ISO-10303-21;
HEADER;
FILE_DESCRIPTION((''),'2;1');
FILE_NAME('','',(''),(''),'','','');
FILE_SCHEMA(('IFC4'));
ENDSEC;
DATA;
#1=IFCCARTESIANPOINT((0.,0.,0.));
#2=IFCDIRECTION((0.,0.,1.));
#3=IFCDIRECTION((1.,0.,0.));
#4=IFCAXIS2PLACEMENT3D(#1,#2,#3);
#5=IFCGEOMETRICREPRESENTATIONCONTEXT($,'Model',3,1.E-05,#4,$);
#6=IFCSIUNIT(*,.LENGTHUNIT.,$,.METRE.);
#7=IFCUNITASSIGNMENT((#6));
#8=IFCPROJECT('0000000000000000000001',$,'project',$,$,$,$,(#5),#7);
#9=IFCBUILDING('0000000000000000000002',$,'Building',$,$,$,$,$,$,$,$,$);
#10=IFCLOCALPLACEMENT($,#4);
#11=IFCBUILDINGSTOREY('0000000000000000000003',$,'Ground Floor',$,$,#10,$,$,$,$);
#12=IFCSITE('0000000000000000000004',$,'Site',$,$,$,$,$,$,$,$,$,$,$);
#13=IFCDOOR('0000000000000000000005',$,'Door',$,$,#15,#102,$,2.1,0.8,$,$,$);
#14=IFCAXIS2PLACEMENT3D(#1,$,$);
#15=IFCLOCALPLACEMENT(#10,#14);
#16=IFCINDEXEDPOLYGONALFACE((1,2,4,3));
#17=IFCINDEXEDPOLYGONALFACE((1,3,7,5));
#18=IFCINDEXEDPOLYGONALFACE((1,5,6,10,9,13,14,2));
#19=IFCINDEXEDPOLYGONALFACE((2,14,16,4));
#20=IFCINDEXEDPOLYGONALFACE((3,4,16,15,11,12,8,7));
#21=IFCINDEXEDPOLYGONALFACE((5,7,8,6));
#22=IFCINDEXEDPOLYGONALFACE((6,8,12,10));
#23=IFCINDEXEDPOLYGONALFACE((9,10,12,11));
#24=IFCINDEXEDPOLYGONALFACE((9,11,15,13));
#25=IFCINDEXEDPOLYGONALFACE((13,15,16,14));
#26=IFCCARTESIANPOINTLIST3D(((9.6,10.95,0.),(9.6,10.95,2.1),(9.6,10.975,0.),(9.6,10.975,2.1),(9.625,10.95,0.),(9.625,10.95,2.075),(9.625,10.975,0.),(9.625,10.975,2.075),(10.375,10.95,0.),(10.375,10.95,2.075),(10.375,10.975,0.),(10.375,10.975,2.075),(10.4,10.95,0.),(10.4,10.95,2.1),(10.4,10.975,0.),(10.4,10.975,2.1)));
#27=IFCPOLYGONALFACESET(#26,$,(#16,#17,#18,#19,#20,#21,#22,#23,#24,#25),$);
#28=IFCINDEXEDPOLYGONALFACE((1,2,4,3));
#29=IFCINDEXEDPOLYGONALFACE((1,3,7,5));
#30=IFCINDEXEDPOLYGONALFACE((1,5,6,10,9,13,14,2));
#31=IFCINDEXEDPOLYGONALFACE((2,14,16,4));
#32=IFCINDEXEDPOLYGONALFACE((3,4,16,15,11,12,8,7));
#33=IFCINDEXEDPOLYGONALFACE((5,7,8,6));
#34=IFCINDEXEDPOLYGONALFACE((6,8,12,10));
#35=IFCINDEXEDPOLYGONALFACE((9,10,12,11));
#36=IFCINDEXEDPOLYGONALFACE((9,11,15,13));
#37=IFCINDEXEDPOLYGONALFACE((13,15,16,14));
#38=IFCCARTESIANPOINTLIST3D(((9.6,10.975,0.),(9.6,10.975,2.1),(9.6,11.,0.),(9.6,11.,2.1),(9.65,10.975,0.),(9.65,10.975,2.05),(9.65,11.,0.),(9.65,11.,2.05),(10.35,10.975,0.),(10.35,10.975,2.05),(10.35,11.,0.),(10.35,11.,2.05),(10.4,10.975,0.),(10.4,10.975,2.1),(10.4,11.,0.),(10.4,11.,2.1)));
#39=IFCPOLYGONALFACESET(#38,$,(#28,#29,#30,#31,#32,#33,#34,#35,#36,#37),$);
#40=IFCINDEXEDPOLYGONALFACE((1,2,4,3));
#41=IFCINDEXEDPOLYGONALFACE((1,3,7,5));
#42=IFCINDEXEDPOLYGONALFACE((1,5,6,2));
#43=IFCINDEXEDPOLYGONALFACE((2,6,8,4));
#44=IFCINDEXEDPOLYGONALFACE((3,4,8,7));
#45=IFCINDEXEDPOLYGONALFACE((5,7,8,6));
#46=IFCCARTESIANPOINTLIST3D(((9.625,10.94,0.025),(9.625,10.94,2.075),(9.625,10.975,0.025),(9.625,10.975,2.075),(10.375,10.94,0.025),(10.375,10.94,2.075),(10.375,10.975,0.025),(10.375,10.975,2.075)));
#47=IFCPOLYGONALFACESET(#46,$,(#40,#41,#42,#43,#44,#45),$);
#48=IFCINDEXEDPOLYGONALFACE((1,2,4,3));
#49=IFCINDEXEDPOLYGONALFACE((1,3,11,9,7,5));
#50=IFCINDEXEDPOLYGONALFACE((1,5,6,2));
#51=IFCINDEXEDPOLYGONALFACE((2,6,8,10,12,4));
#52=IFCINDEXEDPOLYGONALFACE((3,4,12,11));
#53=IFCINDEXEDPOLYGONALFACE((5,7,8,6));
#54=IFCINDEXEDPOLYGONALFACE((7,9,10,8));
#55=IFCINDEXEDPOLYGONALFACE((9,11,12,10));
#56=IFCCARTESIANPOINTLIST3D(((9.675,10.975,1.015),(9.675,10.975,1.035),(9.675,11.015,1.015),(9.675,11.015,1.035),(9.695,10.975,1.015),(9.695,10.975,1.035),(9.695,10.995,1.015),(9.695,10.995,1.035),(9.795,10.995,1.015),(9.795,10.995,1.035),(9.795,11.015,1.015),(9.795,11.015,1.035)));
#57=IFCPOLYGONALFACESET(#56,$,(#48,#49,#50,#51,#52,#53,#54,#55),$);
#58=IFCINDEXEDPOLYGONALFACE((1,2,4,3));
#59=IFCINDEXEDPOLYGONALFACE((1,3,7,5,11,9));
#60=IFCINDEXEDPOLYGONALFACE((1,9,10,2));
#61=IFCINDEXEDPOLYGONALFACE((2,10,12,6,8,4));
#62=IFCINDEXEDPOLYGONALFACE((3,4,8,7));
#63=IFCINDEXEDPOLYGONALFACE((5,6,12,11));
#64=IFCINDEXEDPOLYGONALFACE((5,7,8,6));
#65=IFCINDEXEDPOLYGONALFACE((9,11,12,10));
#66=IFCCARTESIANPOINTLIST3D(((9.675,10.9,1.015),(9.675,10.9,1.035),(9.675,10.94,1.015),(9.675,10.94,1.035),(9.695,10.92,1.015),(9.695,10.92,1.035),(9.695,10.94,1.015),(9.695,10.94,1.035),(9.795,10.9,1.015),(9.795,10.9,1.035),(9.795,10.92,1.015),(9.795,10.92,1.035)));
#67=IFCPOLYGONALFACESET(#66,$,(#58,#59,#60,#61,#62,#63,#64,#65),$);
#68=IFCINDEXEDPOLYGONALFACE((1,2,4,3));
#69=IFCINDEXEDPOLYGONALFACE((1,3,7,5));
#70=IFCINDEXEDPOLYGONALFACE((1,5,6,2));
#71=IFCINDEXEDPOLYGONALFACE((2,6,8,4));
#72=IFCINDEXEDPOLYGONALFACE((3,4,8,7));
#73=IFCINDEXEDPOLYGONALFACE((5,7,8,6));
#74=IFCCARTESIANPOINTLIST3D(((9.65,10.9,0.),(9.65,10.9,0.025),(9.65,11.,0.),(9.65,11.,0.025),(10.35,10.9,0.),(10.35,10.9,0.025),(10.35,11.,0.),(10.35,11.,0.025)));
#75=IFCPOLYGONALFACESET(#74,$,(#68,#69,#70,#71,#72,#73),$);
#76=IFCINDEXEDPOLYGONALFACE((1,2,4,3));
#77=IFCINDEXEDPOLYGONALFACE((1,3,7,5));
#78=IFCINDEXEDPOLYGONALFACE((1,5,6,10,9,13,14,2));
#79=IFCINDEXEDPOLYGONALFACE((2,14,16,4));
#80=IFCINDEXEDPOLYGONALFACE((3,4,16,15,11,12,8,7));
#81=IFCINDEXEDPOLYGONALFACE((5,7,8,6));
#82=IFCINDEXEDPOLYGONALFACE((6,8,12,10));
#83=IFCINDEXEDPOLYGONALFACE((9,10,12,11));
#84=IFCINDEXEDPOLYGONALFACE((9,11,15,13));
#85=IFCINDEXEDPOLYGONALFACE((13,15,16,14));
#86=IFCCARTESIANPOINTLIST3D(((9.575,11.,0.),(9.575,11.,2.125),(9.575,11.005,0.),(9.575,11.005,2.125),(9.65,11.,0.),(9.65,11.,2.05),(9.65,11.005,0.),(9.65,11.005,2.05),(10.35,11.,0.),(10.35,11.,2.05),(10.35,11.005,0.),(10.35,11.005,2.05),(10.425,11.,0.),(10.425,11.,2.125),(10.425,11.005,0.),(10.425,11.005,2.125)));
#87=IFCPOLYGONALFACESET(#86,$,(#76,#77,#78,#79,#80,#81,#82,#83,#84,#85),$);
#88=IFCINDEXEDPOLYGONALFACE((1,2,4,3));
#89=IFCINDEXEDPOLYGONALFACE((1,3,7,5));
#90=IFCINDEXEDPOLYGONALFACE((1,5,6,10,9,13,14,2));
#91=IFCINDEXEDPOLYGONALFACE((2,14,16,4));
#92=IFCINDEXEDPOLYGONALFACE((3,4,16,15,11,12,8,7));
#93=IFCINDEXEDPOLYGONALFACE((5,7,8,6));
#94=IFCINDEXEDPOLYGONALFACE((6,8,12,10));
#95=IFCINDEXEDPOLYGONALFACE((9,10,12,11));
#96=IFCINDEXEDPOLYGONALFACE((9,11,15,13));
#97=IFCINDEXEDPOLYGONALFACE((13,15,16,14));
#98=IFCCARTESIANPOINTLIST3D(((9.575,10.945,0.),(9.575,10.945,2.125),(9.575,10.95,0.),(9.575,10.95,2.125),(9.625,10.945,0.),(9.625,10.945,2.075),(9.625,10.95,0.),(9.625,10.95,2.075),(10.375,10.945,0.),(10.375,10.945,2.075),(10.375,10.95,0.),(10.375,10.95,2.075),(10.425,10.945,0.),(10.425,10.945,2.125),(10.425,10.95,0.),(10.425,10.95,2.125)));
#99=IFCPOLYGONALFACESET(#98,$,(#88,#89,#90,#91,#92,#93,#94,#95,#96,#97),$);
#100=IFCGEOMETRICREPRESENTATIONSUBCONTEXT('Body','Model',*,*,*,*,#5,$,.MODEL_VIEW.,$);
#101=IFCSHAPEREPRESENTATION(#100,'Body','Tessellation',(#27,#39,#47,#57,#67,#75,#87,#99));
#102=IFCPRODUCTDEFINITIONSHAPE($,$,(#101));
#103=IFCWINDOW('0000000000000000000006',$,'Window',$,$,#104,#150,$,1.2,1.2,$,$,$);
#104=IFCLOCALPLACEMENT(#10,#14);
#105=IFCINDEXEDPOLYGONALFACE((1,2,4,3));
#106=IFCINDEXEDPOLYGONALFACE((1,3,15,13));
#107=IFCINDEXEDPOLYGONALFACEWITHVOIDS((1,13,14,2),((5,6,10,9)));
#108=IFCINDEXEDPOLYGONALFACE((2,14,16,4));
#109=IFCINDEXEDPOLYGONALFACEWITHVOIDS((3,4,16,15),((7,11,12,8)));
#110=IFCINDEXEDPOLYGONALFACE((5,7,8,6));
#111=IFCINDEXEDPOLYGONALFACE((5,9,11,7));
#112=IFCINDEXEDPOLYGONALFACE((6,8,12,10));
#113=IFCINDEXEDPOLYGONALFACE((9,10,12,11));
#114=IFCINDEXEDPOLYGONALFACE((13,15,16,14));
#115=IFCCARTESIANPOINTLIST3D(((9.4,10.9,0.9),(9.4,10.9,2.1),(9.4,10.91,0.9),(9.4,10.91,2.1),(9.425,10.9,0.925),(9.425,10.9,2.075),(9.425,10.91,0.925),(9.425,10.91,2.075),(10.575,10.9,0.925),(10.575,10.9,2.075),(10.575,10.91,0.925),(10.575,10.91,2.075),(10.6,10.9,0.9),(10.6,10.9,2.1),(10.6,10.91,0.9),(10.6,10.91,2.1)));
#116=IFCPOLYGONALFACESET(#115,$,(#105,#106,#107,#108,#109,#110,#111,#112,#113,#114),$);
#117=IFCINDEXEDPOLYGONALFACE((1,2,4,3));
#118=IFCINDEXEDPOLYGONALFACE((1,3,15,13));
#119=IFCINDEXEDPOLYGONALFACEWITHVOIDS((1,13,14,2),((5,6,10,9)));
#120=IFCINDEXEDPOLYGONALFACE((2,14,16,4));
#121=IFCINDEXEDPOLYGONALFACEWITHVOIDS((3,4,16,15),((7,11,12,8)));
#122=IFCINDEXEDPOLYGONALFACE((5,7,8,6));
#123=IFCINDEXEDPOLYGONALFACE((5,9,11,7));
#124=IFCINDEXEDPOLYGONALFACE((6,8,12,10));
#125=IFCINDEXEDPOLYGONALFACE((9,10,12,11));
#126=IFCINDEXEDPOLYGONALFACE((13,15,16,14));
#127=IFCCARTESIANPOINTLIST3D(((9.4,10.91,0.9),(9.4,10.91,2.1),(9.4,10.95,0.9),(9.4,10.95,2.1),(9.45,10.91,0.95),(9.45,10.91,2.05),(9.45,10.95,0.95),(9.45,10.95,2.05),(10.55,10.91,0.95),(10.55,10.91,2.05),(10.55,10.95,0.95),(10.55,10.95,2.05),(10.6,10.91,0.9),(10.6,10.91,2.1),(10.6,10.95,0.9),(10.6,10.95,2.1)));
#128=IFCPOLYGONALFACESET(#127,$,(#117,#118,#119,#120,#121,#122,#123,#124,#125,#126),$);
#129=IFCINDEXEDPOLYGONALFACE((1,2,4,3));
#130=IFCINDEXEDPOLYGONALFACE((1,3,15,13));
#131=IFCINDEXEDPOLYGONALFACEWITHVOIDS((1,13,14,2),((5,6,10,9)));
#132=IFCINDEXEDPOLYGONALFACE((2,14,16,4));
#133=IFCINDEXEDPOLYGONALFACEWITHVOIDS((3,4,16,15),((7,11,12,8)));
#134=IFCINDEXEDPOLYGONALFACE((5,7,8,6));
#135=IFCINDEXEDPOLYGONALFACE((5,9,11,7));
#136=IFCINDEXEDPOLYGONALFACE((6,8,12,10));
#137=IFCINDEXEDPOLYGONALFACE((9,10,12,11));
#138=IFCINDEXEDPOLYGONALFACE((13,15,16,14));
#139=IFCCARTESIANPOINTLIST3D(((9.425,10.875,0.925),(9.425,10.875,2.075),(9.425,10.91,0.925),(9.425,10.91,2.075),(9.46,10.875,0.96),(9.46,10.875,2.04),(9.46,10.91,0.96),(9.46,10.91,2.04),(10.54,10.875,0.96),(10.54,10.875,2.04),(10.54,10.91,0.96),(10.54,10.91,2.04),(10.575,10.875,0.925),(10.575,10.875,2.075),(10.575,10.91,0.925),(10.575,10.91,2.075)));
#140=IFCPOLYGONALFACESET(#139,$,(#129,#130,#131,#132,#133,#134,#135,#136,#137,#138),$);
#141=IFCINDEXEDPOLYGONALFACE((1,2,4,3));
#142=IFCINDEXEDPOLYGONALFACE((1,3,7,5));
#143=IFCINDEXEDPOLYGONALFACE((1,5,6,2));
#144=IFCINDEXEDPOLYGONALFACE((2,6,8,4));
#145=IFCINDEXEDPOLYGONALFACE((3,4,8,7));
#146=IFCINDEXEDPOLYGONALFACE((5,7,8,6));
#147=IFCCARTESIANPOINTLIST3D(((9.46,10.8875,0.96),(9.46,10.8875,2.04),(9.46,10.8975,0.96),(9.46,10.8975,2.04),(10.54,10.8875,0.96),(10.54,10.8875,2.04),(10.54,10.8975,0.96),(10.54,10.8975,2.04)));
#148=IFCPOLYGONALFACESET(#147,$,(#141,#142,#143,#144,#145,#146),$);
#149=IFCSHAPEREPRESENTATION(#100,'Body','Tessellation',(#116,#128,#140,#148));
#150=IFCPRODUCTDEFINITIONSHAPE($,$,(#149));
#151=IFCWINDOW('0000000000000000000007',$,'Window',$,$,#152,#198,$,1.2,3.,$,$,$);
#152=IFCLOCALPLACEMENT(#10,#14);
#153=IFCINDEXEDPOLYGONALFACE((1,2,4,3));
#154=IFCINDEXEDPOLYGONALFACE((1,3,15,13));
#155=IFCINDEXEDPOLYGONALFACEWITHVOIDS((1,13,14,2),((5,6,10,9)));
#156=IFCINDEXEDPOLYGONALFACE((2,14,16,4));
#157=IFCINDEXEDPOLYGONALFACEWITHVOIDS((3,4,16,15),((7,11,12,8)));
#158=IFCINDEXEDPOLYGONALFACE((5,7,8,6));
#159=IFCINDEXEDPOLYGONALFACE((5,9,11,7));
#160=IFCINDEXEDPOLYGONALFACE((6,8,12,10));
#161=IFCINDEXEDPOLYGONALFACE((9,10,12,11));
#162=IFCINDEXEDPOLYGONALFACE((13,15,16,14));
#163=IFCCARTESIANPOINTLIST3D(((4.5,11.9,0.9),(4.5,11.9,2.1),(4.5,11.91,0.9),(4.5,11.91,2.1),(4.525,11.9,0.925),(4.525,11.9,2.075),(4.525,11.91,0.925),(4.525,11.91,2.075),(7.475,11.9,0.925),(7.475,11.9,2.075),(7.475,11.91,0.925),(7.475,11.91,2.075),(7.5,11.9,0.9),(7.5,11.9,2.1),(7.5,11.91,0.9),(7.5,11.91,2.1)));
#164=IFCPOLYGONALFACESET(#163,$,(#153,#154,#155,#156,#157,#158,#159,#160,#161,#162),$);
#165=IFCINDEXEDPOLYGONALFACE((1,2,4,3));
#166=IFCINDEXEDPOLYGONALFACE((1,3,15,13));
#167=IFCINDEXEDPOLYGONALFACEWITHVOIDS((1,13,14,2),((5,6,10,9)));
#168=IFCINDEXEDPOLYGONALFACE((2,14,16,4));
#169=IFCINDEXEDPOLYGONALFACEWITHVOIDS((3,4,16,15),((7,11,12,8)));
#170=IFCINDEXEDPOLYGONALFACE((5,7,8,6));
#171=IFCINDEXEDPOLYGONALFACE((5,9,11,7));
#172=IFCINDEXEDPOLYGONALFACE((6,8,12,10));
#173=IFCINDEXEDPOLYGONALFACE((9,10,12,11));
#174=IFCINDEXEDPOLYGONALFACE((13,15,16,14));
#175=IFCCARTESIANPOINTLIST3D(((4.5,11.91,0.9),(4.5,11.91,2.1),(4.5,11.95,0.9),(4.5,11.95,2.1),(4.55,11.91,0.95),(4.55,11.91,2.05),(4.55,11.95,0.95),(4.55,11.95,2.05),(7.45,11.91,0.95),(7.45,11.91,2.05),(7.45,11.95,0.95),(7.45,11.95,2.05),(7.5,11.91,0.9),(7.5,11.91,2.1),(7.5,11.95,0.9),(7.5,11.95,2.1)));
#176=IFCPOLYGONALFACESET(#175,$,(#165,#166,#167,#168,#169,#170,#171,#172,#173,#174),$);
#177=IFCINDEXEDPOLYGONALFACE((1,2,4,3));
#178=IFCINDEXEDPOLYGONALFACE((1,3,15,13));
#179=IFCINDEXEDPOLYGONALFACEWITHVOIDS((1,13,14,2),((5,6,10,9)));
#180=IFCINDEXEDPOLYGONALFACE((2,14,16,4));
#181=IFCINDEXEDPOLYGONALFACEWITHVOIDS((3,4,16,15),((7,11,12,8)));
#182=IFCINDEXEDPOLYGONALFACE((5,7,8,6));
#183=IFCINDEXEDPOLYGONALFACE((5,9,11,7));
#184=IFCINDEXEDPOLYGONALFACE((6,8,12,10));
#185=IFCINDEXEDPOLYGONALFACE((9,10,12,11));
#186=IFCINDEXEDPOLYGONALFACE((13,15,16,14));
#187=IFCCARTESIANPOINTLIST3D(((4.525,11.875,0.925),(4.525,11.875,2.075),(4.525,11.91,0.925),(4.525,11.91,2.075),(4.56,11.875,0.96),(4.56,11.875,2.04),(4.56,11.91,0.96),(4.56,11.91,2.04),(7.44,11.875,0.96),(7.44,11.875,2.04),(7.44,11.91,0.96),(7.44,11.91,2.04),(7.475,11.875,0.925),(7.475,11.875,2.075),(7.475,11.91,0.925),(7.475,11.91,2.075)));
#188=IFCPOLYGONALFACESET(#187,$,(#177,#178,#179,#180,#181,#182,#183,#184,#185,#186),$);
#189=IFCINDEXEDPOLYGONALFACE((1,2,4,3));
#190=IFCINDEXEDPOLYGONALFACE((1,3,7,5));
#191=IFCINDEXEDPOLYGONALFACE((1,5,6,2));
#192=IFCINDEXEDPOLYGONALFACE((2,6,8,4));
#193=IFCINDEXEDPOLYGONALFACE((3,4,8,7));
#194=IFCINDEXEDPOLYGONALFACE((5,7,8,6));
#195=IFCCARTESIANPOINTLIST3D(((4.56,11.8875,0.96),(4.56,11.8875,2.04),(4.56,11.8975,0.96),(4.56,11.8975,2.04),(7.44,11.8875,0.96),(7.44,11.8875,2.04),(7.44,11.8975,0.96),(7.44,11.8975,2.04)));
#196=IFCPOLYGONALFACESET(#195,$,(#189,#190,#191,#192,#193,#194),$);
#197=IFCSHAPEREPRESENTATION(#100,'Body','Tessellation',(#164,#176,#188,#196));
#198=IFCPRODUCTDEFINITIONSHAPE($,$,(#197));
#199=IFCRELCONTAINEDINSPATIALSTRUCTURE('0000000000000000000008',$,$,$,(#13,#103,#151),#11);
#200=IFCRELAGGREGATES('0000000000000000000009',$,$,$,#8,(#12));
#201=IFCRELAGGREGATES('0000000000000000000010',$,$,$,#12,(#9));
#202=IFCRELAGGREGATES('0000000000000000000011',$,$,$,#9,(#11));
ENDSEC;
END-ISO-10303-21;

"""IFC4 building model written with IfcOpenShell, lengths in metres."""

from ifc_helpers import new_model, si_unit, frame, origin_with_axes, place, context, subcontext, project, spatial, line, indexed_curve, outline, extrude, element, save


model = new_model("IFC4")

# Units and contexts
model_context = context("Model", 3, precision=1e-05, world=origin_with_axes())
body_context = subcontext(model_context, "Body", "Model", "MODEL_VIEW")
ifc_project = project(units=[si_unit("LENGTHUNIT", "METRE")], contexts=[model_context])

# Site, building, storey
site = spatial("IfcSite", under=ifc_project, Name="Site")
building = spatial("IfcBuilding", under=site, Name="Building")
storey_placement = place(None, origin_with_axes())
storey = spatial("IfcBuildingStorey", under=building, at=storey_placement, Name="Ground Floor")

# Door
door_1_placement = place(storey_placement, frame((10.4, 11.0, 0.0), z_axis=(0.0, 0.0, 1.0), x_axis=(-1.0, 0.0, 0.0)))
element("IfcDoor", 1, at=door_1_placement, inside=storey, Name="Door", OverallHeight=2.1, OverallWidth=0.8, context=body_context, shape_type="SweptSolid", body=[
    extrude(outline(indexed_curve([(0.0, 0.0), (0.0, 2.1), (0.8, 2.1), (0.8, 0.0), (0.775, 0.0), (0.775, 2.075), (0.025, 2.075), (0.025, 0.0)], segments=[line(1, 2, 3, 4, 5, 6, 7, 8, 1)])), frame((0.0, 0.025, 0.0), z_axis=(0.0, -1.0, 0.0), x_axis=(1.0, 0.0, 0.0)), (0.0, 0.0, -1.0), 0.025),
    extrude(outline(indexed_curve([(0.0, 0.0), (0.0, 2.1), (0.8, 2.1), (0.8, 0.0), (0.75, 0.0), (0.75, 2.05), (0.05, 2.05), (0.05, 0.0)], segments=[line(1, 2, 3, 4, 5, 6, 7, 8, 1)])), frame((0.0, 0.0, 0.0), z_axis=(0.0, -1.0, 0.0), x_axis=(1.0, 0.0, 0.0)), (0.0, 0.0, -1.0), 0.025),
    extrude(outline(indexed_curve([(0.0, 0.0), (0.75, 0.0), (0.75, 0.035), (0.0, 0.035)], segments=[line(1, 2, 3, 4, 1)])), frame((0.025, 0.025, 0.025), z_axis=(0.0, 0.0, 1.0), x_axis=(1.0, 0.0, 0.0)), (0.0, 0.0, 1.0), 2.05),
    extrude(outline(indexed_curve([(0.0, 0.0), (0.0, -0.04), (-0.12, -0.04), (-0.12, -0.02), (-0.02, -0.02), (-0.02, 0.0)], segments=[line(1, 2, 3, 4, 5, 6, 1)])), frame((0.725, 0.025, 1.015), z_axis=(0.0, 0.0, 1.0), x_axis=(1.0, 0.0, 0.0)), (0.0, 0.0, 1.0), 0.02),
    extrude(outline(indexed_curve([(0.0, 0.0), (0.0, 0.04), (-0.12, 0.04), (-0.12, 0.02), (-0.02, 0.02), (-0.02, 0.0)], segments=[line(1, 2, 3, 4, 5, 6, 1)])), frame((0.725, 0.06, 1.015), z_axis=(0.0, 0.0, 1.0), x_axis=(1.0, 0.0, 0.0)), (0.0, 0.0, 1.0), 0.02),
    extrude(outline(indexed_curve([(0.0, 0.0), (0.7, 0.0), (0.7, 0.1), (0.0, 0.1)], segments=[line(1, 2, 3, 4, 1)])), frame((0.05, 0.0, 0.0), z_axis=(0.0, 0.0, 1.0), x_axis=(1.0, 0.0, 0.0)), (0.0, 0.0, 1.0), 0.025),
    extrude(outline(indexed_curve([(0.0, 0.0), (0.0, 2.125), (0.85, 2.125), (0.85, 0.0), (0.775, 0.0), (0.775, 2.05), (0.075, 2.05), (0.075, 0.0)], segments=[line(1, 2, 3, 4, 5, 6, 7, 8, 1)])), frame((-0.025, -0.005, 0.0), z_axis=(0.0, -1.0, 0.0), x_axis=(1.0, 0.0, 0.0)), (0.0, 0.0, -1.0), 0.005),
    extrude(outline(indexed_curve([(0.0, 0.0), (0.0, 2.125), (0.85, 2.125), (0.85, 0.0), (0.8, 0.0), (0.8, 2.075), (0.05, 2.075), (0.05, 0.0)], segments=[line(1, 2, 3, 4, 5, 6, 7, 8, 1)])), frame((-0.025, 0.05, 0.0), z_axis=(0.0, -1.0, 0.0), x_axis=(1.0, 0.0, 0.0)), (0.0, 0.0, -1.0), 0.005),
])

# Windows
window_1_placement = place(storey_placement, frame((10.6, 11.0, 0.9), z_axis=(0.0, 0.0, 1.0), x_axis=(-1.0, 0.0, 0.0)))
element("IfcWindow", 2, at=window_1_placement, inside=storey, Name="Window", OverallHeight=1.2, OverallWidth=1.2, context=body_context, shape_type="SweptSolid", body=[
    extrude(outline(indexed_curve([(0.0, 0.0), (1.2, 0.0), (1.2, 1.2), (0.0, 1.2)], segments=[line(1, 2, 3, 4, 1)]), holes=[indexed_curve([(0.025, 0.025), (1.175, 0.025), (1.175, 1.175), (0.025, 1.175)], segments=[line(1, 2, 3, 4, 1)])]), frame((0.0, 0.09, 0.0), z_axis=(0.0, -1.0, 0.0), x_axis=(1.0, 0.0, 0.0)), (0.0, 0.0, -1.0), 0.01),
    extrude(outline(indexed_curve([(0.0, 0.0), (1.2, 0.0), (1.2, 1.2), (0.0, 1.2)], segments=[line(1, 2, 3, 4, 1)]), holes=[indexed_curve([(0.05, 0.05), (1.15, 0.05), (1.15, 1.15), (0.05, 1.15)], segments=[line(1, 2, 3, 4, 1)])]), frame((0.0, 0.05, 0.0), z_axis=(0.0, -1.0, 0.0), x_axis=(1.0, 0.0, 0.0)), (0.0, 0.0, -1.0), 0.04),
    extrude(outline(indexed_curve([(0.0, 0.0), (1.15, 0.0), (1.15, 1.15), (0.0, 1.15)], segments=[line(1, 2, 3, 4, 1)]), holes=[indexed_curve([(0.035, 0.035), (1.115, 0.035), (1.115, 1.115), (0.035, 1.115)], segments=[line(1, 2, 3, 4, 1)])]), frame((0.025, 0.09, 0.025), z_axis=(0.0, -1.0, 0.0), x_axis=(1.0, 0.0, 0.0)), (0.0, 0.0, -1.0), 0.035),
    extrude(outline(indexed_curve([(0.035, 0.035), (1.115, 0.035), (1.115, 1.115), (0.035, 1.115)], segments=[line(1, 2, 3, 4, 1)])), frame((0.025, 0.1025, 0.025), z_axis=(0.0, -1.0, 0.0), x_axis=(1.0, 0.0, 0.0)), (0.0, 0.0, -1.0), 0.01),
])
window_2_placement = place(storey_placement, frame((7.5, 12.0, 0.9), z_axis=(0.0, 0.0, 1.0), x_axis=(-1.0, 0.0, 0.0)))
element("IfcWindow", 3, at=window_2_placement, inside=storey, Name="Window", OverallHeight=1.2, OverallWidth=3.0, context=body_context, shape_type="SweptSolid", body=[
    extrude(outline(indexed_curve([(0.0, 0.0), (3.0, 0.0), (3.0, 1.2), (0.0, 1.2)], segments=[line(1, 2, 3, 4, 1)]), holes=[indexed_curve([(0.025, 0.025), (2.975, 0.025), (2.975, 1.175), (0.025, 1.175)], segments=[line(1, 2, 3, 4, 1)])]), frame((0.0, 0.09, 0.0), z_axis=(0.0, -1.0, 0.0), x_axis=(1.0, 0.0, 0.0)), (0.0, 0.0, -1.0), 0.01),
    extrude(outline(indexed_curve([(0.0, 0.0), (3.0, 0.0), (3.0, 1.2), (0.0, 1.2)], segments=[line(1, 2, 3, 4, 1)]), holes=[indexed_curve([(0.05, 0.05), (2.95, 0.05), (2.95, 1.15), (0.05, 1.15)], segments=[line(1, 2, 3, 4, 1)])]), frame((0.0, 0.05, 0.0), z_axis=(0.0, -1.0, 0.0), x_axis=(1.0, 0.0, 0.0)), (0.0, 0.0, -1.0), 0.04),
    extrude(outline(indexed_curve([(0.0, 0.0), (2.95, 0.0), (2.95, 1.15), (0.0, 1.15)], segments=[line(1, 2, 3, 4, 1)]), holes=[indexed_curve([(0.035, 0.035), (2.915, 0.035), (2.915, 1.115), (0.035, 1.115)], segments=[line(1, 2, 3, 4, 1)])]), frame((0.025, 0.09, 0.025), z_axis=(0.0, -1.0, 0.0), x_axis=(1.0, 0.0, 0.0)), (0.0, 0.0, -1.0), 0.035),
    extrude(outline(indexed_curve([(0.035, 0.035), (2.915, 0.035), (2.915, 1.115), (0.035, 1.115)], segments=[line(1, 2, 3, 4, 1)])), frame((0.025, 0.1025, 0.025), z_axis=(0.0, -1.0, 0.0), x_axis=(1.0, 0.0, 0.0)), (0.0, 0.0, -1.0), 0.01),
])

save(model, "model.ifc")
